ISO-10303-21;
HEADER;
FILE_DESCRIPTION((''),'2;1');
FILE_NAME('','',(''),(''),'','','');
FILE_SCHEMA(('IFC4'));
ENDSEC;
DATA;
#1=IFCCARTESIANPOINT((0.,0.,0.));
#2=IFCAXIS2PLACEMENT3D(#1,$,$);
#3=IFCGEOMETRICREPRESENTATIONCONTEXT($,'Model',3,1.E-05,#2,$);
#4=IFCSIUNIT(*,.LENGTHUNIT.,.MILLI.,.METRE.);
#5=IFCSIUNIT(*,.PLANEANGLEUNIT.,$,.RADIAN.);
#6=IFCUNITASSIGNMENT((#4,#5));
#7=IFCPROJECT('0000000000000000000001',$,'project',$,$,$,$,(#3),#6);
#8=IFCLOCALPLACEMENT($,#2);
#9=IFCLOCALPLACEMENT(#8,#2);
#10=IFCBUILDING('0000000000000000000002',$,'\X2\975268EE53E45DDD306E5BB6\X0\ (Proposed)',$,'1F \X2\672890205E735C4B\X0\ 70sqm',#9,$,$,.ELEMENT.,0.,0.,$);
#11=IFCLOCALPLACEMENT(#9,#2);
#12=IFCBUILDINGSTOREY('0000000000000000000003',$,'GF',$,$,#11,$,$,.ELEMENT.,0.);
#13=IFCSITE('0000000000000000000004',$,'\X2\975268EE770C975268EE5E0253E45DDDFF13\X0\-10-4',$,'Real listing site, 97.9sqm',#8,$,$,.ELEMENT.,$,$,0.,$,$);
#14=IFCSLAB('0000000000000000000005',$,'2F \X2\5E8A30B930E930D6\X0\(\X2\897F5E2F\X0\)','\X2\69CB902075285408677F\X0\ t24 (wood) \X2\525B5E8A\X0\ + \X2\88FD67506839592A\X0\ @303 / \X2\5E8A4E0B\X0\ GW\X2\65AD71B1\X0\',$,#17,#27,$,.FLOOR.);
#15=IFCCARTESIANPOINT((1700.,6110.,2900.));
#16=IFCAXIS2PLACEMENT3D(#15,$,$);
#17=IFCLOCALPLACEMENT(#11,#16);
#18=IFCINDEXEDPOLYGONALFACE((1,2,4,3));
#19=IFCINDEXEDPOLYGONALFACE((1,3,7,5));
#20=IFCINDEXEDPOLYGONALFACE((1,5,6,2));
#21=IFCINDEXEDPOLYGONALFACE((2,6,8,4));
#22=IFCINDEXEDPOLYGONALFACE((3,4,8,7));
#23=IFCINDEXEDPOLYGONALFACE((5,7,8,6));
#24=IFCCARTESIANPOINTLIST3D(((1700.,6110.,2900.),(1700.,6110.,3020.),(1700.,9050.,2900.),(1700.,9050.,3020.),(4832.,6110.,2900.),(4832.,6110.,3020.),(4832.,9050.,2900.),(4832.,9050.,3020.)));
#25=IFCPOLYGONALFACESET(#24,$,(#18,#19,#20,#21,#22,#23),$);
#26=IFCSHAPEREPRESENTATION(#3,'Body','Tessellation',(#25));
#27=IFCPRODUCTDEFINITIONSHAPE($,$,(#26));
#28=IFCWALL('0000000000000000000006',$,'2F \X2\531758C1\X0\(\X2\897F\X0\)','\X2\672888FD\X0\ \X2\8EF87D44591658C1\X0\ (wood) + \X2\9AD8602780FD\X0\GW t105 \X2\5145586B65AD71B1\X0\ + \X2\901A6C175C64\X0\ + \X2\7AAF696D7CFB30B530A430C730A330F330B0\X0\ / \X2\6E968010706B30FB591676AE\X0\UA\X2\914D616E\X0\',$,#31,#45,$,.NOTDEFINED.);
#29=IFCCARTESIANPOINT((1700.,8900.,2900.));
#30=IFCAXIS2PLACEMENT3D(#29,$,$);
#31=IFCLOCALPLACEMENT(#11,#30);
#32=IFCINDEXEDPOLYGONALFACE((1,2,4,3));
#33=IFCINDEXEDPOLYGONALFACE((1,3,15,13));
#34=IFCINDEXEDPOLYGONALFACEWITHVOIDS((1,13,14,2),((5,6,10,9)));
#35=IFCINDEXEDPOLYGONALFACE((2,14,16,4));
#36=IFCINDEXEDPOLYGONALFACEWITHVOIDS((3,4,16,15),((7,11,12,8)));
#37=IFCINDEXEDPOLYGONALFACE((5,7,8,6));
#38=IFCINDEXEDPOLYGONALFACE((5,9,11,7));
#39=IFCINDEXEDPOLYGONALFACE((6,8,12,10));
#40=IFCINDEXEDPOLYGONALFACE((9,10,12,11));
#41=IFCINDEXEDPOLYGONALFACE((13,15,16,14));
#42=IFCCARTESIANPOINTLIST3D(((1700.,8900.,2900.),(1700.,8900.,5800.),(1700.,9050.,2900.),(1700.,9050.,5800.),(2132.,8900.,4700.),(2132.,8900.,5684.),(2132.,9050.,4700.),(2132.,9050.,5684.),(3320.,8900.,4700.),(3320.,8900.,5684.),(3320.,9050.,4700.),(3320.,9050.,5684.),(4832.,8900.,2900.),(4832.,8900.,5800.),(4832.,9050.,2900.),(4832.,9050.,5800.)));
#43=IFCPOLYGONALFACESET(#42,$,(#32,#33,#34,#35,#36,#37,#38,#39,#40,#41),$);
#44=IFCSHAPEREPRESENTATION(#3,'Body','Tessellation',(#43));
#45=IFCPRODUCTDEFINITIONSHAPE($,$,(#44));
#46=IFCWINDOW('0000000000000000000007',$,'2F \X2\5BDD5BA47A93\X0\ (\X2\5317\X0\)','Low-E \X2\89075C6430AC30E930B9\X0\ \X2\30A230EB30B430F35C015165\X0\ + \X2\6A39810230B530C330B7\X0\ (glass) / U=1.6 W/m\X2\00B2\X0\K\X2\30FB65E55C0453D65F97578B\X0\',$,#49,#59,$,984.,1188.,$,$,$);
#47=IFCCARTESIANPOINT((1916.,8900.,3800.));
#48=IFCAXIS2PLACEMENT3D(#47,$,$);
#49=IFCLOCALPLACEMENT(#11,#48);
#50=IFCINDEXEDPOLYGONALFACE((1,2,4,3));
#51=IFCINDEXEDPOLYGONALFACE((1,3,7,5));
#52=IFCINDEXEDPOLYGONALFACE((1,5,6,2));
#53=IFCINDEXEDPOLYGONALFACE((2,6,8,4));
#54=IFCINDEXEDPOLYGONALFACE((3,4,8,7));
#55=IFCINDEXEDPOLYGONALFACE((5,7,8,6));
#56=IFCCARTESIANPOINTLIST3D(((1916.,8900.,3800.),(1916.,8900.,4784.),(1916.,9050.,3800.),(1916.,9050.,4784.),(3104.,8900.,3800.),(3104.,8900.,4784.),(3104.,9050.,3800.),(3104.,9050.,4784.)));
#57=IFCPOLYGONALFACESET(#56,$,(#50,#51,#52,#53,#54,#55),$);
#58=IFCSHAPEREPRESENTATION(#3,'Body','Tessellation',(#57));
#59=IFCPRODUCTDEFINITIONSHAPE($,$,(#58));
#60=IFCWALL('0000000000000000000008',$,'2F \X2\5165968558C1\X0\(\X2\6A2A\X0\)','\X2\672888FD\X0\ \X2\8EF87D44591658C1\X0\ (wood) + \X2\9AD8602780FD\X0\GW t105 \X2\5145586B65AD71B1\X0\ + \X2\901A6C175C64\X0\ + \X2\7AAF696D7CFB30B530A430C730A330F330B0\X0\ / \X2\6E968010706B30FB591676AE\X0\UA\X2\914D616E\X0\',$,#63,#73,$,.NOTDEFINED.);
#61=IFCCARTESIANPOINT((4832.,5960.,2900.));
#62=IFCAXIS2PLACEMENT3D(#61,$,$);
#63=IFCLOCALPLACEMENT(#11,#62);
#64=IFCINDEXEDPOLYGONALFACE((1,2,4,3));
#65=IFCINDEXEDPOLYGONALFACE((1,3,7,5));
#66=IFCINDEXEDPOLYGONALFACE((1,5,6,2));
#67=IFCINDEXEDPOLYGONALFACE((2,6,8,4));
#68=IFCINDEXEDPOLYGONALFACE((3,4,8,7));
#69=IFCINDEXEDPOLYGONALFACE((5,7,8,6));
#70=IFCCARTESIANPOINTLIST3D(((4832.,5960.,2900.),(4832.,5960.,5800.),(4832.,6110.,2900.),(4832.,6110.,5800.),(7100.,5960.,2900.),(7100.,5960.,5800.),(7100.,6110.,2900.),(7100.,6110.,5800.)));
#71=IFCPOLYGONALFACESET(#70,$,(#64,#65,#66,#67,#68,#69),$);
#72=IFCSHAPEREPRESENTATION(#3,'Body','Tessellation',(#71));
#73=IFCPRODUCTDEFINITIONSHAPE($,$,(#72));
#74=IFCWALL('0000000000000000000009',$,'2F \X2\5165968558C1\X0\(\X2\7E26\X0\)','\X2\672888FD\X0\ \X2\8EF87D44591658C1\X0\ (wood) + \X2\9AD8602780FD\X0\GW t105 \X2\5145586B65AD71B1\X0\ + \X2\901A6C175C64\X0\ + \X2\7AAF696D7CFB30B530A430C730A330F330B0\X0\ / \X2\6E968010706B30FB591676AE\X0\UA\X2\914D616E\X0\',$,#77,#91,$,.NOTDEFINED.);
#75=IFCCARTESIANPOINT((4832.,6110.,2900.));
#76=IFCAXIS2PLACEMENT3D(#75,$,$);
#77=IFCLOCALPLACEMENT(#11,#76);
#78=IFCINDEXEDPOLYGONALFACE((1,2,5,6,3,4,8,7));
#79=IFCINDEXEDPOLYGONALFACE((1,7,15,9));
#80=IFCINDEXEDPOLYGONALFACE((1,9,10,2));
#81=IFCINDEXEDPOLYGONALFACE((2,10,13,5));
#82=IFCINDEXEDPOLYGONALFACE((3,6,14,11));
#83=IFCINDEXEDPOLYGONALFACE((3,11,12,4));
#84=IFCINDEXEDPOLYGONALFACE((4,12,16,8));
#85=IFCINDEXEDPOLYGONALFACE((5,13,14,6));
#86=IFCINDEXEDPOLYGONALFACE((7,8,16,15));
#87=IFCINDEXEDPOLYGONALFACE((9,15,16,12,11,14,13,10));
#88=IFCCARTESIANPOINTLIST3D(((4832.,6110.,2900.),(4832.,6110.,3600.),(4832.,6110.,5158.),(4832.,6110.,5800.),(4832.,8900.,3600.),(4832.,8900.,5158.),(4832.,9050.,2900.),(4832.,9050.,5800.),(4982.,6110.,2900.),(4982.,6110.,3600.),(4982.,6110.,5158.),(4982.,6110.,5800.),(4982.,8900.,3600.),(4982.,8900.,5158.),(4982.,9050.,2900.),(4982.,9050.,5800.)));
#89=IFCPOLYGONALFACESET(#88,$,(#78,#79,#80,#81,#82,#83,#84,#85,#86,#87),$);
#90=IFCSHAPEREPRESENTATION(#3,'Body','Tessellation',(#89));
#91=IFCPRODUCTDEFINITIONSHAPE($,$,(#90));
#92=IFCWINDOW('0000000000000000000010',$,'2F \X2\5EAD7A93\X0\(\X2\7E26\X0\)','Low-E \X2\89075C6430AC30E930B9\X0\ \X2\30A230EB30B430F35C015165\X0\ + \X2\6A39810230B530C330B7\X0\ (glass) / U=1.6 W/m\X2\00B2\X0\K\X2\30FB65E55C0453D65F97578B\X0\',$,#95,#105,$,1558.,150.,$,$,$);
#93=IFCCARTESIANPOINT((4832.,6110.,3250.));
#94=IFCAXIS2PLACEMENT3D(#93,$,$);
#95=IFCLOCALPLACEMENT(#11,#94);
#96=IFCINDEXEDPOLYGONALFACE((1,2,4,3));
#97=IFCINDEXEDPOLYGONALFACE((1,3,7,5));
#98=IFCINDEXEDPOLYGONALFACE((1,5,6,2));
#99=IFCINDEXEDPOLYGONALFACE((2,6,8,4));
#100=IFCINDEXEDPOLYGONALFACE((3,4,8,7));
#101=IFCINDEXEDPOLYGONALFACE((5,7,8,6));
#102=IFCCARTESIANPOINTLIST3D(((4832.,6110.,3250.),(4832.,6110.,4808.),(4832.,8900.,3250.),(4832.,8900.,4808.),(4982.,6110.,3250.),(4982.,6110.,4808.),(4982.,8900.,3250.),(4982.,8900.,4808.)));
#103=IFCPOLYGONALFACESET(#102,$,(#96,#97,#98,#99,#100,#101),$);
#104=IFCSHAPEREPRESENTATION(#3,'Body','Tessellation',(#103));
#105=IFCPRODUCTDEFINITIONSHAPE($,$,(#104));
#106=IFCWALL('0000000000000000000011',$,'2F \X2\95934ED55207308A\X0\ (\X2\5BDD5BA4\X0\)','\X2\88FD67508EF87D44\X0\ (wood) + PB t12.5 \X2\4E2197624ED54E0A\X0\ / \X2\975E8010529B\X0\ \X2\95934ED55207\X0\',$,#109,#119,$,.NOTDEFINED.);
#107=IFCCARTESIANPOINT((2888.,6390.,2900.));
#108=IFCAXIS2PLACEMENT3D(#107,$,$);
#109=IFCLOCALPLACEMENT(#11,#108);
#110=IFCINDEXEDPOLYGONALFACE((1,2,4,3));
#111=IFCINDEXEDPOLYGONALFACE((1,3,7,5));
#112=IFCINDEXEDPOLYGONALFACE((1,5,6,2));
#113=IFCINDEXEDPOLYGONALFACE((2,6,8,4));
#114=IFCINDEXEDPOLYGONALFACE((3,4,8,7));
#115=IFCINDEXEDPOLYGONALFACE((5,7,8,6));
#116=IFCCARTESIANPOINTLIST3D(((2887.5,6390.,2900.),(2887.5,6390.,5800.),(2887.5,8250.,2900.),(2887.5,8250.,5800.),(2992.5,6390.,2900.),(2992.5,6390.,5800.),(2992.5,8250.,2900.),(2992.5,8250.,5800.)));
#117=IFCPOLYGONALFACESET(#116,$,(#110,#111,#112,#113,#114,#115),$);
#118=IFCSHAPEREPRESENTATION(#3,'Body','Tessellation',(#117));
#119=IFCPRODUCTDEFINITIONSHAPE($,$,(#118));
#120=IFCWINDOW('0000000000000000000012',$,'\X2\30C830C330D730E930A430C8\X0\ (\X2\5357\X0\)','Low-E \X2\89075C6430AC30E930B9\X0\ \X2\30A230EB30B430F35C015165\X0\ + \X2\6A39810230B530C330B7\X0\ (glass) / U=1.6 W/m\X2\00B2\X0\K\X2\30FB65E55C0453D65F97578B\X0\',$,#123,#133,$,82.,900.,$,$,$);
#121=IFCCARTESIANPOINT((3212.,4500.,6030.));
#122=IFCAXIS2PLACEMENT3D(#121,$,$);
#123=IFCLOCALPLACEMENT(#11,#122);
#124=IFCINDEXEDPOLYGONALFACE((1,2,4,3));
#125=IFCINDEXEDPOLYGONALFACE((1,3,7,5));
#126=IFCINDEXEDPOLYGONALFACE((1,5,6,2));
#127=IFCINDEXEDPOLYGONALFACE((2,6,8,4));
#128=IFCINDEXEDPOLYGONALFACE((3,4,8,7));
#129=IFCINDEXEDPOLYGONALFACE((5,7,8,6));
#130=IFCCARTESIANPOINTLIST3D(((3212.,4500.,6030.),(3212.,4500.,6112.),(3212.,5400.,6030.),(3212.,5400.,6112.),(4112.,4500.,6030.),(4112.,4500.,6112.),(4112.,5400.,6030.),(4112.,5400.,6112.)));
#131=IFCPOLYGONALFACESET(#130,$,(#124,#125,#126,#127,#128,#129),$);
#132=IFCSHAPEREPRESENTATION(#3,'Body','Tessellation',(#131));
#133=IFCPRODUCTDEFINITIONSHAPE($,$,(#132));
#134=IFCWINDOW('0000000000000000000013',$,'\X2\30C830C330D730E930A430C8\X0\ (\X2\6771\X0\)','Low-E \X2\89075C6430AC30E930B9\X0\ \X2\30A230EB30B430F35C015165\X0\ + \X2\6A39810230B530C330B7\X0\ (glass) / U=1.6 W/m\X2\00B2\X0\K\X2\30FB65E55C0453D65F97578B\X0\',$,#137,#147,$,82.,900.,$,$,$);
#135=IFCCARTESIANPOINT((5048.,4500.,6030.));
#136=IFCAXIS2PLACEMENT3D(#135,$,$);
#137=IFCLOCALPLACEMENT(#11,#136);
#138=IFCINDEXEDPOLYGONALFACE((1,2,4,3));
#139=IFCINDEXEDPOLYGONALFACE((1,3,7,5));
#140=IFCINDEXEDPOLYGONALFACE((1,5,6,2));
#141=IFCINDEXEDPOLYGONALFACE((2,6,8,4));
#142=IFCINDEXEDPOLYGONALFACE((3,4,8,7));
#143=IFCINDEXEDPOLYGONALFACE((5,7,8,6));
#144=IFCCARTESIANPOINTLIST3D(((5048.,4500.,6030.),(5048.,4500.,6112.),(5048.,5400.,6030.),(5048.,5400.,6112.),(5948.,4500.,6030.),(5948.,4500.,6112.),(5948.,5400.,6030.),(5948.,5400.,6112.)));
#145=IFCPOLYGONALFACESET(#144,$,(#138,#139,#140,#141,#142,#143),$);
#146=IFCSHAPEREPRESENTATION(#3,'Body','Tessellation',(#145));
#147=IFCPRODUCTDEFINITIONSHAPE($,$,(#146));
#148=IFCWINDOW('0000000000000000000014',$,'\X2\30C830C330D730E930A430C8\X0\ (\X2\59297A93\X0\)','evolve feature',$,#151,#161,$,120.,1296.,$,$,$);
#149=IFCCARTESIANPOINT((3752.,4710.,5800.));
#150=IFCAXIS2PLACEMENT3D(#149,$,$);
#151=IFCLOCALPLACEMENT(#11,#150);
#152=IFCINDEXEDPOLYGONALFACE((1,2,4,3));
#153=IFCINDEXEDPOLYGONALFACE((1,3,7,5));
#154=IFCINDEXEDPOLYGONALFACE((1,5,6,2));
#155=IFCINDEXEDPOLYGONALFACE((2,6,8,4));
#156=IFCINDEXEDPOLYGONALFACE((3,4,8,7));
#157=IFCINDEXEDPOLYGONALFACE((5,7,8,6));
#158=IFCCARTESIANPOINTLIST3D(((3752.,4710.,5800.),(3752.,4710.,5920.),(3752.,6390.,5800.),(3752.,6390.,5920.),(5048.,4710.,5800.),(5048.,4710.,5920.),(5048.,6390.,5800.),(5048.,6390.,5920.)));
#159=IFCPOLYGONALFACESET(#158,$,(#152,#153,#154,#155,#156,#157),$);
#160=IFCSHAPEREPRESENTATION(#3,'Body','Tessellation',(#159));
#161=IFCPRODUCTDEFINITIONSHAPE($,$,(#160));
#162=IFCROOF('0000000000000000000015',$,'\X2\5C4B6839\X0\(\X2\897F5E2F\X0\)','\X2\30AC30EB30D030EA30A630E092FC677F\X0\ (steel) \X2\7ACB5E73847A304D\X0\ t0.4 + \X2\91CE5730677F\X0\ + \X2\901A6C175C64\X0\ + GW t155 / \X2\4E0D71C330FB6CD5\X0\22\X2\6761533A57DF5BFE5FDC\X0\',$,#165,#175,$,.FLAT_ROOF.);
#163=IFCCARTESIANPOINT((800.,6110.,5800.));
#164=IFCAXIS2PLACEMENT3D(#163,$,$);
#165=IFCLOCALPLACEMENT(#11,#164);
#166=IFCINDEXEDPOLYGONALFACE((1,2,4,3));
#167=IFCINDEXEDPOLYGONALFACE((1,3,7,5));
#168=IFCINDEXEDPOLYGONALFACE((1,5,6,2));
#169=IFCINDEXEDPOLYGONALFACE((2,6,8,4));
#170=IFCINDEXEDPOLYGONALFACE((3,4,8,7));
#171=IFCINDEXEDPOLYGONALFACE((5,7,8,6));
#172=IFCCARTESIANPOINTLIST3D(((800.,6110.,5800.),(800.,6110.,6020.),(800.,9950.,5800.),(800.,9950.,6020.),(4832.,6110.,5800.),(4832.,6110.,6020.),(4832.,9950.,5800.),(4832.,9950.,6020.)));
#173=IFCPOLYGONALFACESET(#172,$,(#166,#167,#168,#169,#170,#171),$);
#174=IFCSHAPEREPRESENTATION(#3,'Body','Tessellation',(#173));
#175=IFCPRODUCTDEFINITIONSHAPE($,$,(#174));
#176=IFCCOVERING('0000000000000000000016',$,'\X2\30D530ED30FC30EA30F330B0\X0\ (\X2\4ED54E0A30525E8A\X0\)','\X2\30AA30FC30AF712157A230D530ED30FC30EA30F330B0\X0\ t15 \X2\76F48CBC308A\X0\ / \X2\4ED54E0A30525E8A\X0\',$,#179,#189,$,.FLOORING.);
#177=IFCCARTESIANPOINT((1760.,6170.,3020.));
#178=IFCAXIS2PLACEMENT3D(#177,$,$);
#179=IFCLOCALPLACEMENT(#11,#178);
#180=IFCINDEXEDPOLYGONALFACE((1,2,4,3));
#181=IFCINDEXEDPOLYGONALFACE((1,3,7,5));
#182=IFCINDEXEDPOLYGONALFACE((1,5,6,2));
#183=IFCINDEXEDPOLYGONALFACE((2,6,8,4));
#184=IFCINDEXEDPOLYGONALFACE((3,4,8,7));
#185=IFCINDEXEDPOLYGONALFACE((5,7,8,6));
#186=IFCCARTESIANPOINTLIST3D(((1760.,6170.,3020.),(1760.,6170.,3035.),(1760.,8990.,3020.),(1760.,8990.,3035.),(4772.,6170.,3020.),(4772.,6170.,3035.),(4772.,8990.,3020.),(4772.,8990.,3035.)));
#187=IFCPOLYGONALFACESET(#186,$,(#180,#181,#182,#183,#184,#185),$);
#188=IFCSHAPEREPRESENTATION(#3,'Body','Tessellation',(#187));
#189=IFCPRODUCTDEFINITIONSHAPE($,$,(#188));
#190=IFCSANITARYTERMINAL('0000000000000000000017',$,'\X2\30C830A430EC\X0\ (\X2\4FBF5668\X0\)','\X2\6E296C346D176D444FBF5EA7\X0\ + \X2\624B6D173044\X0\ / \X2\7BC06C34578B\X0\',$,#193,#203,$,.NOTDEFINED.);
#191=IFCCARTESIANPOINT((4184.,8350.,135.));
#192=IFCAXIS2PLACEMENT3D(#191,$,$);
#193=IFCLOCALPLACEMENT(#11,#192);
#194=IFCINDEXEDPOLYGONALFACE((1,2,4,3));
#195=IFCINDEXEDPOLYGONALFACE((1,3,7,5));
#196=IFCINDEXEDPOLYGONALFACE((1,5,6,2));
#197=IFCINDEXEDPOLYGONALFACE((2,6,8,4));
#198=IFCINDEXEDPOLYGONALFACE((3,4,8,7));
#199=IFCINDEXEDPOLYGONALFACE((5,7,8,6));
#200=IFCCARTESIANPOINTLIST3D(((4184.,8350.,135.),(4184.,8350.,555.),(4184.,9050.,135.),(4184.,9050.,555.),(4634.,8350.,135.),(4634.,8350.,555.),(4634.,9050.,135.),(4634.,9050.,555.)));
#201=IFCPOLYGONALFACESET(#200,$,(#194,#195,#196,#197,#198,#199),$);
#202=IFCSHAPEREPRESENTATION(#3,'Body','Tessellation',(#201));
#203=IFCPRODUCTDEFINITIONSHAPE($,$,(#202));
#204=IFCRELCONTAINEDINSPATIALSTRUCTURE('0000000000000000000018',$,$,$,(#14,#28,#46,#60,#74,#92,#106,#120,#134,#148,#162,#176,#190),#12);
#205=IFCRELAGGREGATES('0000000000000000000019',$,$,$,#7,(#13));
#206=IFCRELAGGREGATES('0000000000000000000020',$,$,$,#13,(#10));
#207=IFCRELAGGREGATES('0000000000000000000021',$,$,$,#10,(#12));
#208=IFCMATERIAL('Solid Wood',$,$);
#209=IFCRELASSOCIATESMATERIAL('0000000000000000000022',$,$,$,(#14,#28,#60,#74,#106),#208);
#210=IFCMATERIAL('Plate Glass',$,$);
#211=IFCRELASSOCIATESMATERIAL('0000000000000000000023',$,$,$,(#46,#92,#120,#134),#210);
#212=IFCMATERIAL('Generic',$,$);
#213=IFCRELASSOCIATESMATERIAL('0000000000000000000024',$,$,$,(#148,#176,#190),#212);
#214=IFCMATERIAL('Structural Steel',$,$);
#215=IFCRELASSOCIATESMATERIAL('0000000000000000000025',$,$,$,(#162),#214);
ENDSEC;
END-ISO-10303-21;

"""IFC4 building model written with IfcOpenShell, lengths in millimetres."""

from ifc_helpers import new_model, si_unit, frame, frame_2d, origin, place, context, project, spatial, rectangle, extrude, material, element, fill, save


model = new_model("IFC4")

# Units and contexts
model_context = context("Model", 3, precision=1e-05, world=origin())
ifc_project = project(units=[si_unit("LENGTHUNIT", "METRE", prefix="MILLI"), si_unit("PLANEANGLEUNIT", "RADIAN")], contexts=[model_context])

# Site, building, storey
site_placement = place(None, origin())
site = spatial("IfcSite", under=ifc_project, at=site_placement, Name="青森県青森市古川３-10-4", ObjectType="Real listing site, 97.9sqm", CompositionType="ELEMENT", RefElevation=0.0)
building_placement = place(site_placement, origin())
building = spatial("IfcBuilding", under=site, at=building_placement, Name="青森古川の家 (Proposed)", ObjectType="1F 木造平屋 70sqm", CompositionType="ELEMENT", ElevationOfRefHeight=0.0, ElevationOfTerrain=0.0)
storey_placement = place(building_placement, origin())
storey = spatial("IfcBuildingStorey", under=building, at=storey_placement, Name="GF", CompositionType="ELEMENT", Elevation=0.0)

# Slab
ifc_material_1 = material(Name="Solid Wood")
slab_placement = place(storey_placement, frame((1700.0, 6110.0, 2900.0)))
element("IfcSlab", 1, at=slab_placement, inside=storey, material=ifc_material_1, Name="2F 床スラブ(西帯)", Description="構造用合板 t24 (wood) 剛床 + 製材根太 @303 / 床下 GW断熱", PredefinedType="FLOOR", context=model_context, shape_type="SweptSolid", body=[
    extrude(rectangle(XDim=3132.0, YDim=2940.0, at=frame_2d((1566.0, 1470.0))), frame((1700.0, 6110.0, 2900.0)), (0.0, 0.0, 1.0), 120.0),
])

# Wall, opening, window
wall_1_placement = place(storey_placement, frame((1700.0, 8900.0, 2900.0)))
wall_1 = element("IfcWall", 2, at=wall_1_placement, inside=storey, material=ifc_material_1, Name="2F 北壁(西)", Description="木製 軸組外壁 (wood) + 高性能GW t105 充填断熱 + 通気層 + 窯業系サイディング / 準耐火・外皮UA配慮", PredefinedType="NOTDEFINED", context=model_context, shape_type="SweptSolid", body=[
    extrude(rectangle(XDim=3132.0, YDim=150.0, at=frame_2d((1566.0, 75.0))), frame((1700.0, 8900.0, 2900.0)), (0.0, 0.0, 1.0), 2900.0),
])
opening_1_placement = place(storey_placement, frame((1916.0, 8900.0, 3800.0)))
opening_1 = element("IfcOpeningElement", 3, at=opening_1_placement, cuts=wall_1, PredefinedType="NOTDEFINED", context=model_context, shape_type="SweptSolid", body=[
    extrude(rectangle(XDim=1188.0, YDim=150.0, at=frame_2d((594.0, 75.0))), frame((1916.0, 8900.0, 3800.0)), (0.0, 0.0, 1.0), 984.0),
])
ifc_material_2 = material(Name="Plate Glass")
window_1_placement = place(storey_placement, frame((1916.0, 8900.0, 3800.0)))
window_1 = element("IfcWindow", 4, at=window_1_placement, inside=storey, material=ifc_material_2, Name="2F 寝室窓 (北)", Description="Low-E 複層ガラス アルゴン封入 + 樹脂サッシ (glass) / U=1.6 W/m²K・日射取得型", OverallHeight=984.0, OverallWidth=1188.0, context=model_context, shape_type="SweptSolid", body=[
    extrude(rectangle(XDim=1188.0, YDim=150.0, at=frame_2d((594.0, 75.0))), frame((1916.0, 8900.0, 3800.0)), (0.0, 0.0, 1.0), 984.0),
])
fill(opening_1, window_1)

# Wall
wall_2_placement = place(storey_placement, frame((4832.0, 5960.0, 2900.0)))
element("IfcWall", 5, at=wall_2_placement, inside=storey, material=ifc_material_1, Name="2F 入隅壁(横)", Description="木製 軸組外壁 (wood) + 高性能GW t105 充填断熱 + 通気層 + 窯業系サイディング / 準耐火・外皮UA配慮", PredefinedType="NOTDEFINED", context=model_context, shape_type="SweptSolid", body=[
    extrude(rectangle(XDim=2268.0, YDim=150.0, at=frame_2d((1134.0, 75.0))), frame((4832.0, 5960.0, 2900.0)), (0.0, 0.0, 1.0), 2900.0),
])

# Wall, opening, window
wall_3_placement = place(storey_placement, frame((4832.0, 6110.0, 2900.0)))
wall_3 = element("IfcWall", 6, at=wall_3_placement, inside=storey, material=ifc_material_1, Name="2F 入隅壁(縦)", Description="木製 軸組外壁 (wood) + 高性能GW t105 充填断熱 + 通気層 + 窯業系サイディング / 準耐火・外皮UA配慮", PredefinedType="NOTDEFINED", context=model_context, shape_type="SweptSolid", body=[
    extrude(rectangle(XDim=150.0, YDim=2940.0, at=frame_2d((75.0, 1470.0))), frame((4832.0, 6110.0, 2900.0)), (0.0, 0.0, 1.0), 2900.0),
])
opening_2_placement = place(storey_placement, frame((4832.0, 6110.0, 3250.0)))
opening_2 = element("IfcOpeningElement", 7, at=opening_2_placement, cuts=wall_3, PredefinedType="NOTDEFINED", context=model_context, shape_type="SweptSolid", body=[
    extrude(rectangle(XDim=150.0, YDim=2790.0, at=frame_2d((75.0, 1395.0))), frame((4832.0, 6110.0, 3250.0)), (0.0, 0.0, 1.0), 1558.0),
])
window_2_placement = place(storey_placement, frame((4832.0, 6110.0, 3250.0)))
window_2 = element("IfcWindow", 8, at=window_2_placement, inside=storey, material=ifc_material_2, Name="2F 庭窓(縦)", Description="Low-E 複層ガラス アルゴン封入 + 樹脂サッシ (glass) / U=1.6 W/m²K・日射取得型", OverallHeight=1558.0, OverallWidth=150.0, context=model_context, shape_type="SweptSolid", body=[
    extrude(rectangle(XDim=150.0, YDim=2790.0, at=frame_2d((75.0, 1395.0))), frame((4832.0, 6110.0, 3250.0)), (0.0, 0.0, 1.0), 1558.0),
])
fill(opening_2, window_2)

# Wall
wall_4_placement = place(storey_placement, frame((2888.0, 6390.0, 2900.0)))
element("IfcWall", 9, at=wall_4_placement, inside=storey, material=ifc_material_1, Name="2F 間仕切り (寝室)", Description="製材軸組 (wood) + PB t12.5 両面仕上 / 非耐力 間仕切", PredefinedType="NOTDEFINED", context=model_context, shape_type="SweptSolid", body=[
    extrude(rectangle(XDim=105.0, YDim=1860.0, at=frame_2d((52.0, 930.0))), frame((2888.0, 6390.0, 2900.0)), (0.0, 0.0, 1.0), 2900.0),
])

# Windows
window_3_placement = place(storey_placement, frame((3212.0, 4500.0, 6030.0)))
element("IfcWindow", 10, at=window_3_placement, inside=storey, material=ifc_material_2, Name="トップライト (南)", Description="Low-E 複層ガラス アルゴン封入 + 樹脂サッシ (glass) / U=1.6 W/m²K・日射取得型", OverallHeight=82.0, OverallWidth=900.0, context=model_context, shape_type="SweptSolid", body=[
    extrude(rectangle(XDim=900.0, YDim=900.0, at=frame_2d((450.0, 450.0))), frame((3212.0, 4500.0, 6030.0)), (0.0, 0.0, 1.0), 82.0),
])
window_4_placement = place(storey_placement, frame((5048.0, 4500.0, 6030.0)))
element("IfcWindow", 11, at=window_4_placement, inside=storey, material=ifc_material_2, Name="トップライト (東)", Description="Low-E 複層ガラス アルゴン封入 + 樹脂サッシ (glass) / U=1.6 W/m²K・日射取得型", OverallHeight=82.0, OverallWidth=900.0, context=model_context, shape_type="SweptSolid", body=[
    extrude(rectangle(XDim=900.0, YDim=900.0, at=frame_2d((450.0, 450.0))), frame((5048.0, 4500.0, 6030.0)), (0.0, 0.0, 1.0), 82.0),
])
ifc_material_3 = material(Name="Generic")
window_5_placement = place(storey_placement, frame((3752.0, 4710.0, 5800.0)))
element("IfcWindow", 12, at=window_5_placement, inside=storey, material=ifc_material_3, Name="トップライト (天窓)", Description="evolve feature", OverallHeight=120.0, OverallWidth=1296.0, context=model_context, shape_type="SweptSolid", body=[
    extrude(rectangle(XDim=1296.0, YDim=1680.0, at=frame_2d((648.0, 840.0))), frame((3752.0, 4710.0, 5800.0)), (0.0, 0.0, 1.0), 120.0),
])

# Roof
ifc_material_4 = material(Name="Structural Steel")
for number, where, name in (
    (13, (800.0, 6110.0, 5800.0), "屋根(西帯)"),
):
    element("IfcRoof", number, at=place(storey_placement, frame(where)), inside=storey, material=ifc_material_4, Name=name, Description="ガルバリウム鋼板 (steel) 立平葺き t0.4 + 野地板 + 通気層 + GW t155 / 不燃・法22条区域対応", PredefinedType="FLAT_ROOF", context=model_context, shape_type="SweptSolid", body=[
        extrude(rectangle(XDim=4032.0, YDim=3840.0, at=frame_2d((2016.0, 1920.0))), frame((800.0, 6110.0, 5800.0)), (0.0, 0.0, 1.0), 220.0),
    ])

# Covering
covering_placement = place(storey_placement, frame((1760.0, 6170.0, 3020.0)))
element("IfcCovering", 14, at=covering_placement, inside=storey, material=ifc_material_3, Name="フローリング (仕上げ床)", Description="オーク無垢フローリング t15 直貼り / 仕上げ床", PredefinedType="FLOORING", context=model_context, shape_type="SweptSolid", body=[
    extrude(rectangle(XDim=3012.0, YDim=2820.0, at=frame_2d((1506.0, 1410.0))), frame((1760.0, 6170.0, 3020.0)), (0.0, 0.0, 1.0), 15.0),
])

# Sanitary terminal
sanitary_terminal_placement = place(storey_placement, frame((4184.0, 8350.0, 135.0)))
element("IfcSanitaryTerminal", 15, at=sanitary_terminal_placement, inside=storey, material=ifc_material_3, Name="トイレ (便器)", Description="温水洗浄便座 + 手洗い / 節水型", PredefinedType="NOTDEFINED", context=model_context, shape_type="SweptSolid", body=[
    extrude(rectangle(XDim=450.0, YDim=700.0, at=frame_2d((225.0, 350.0))), frame((4184.0, 8350.0, 135.0)), (0.0, 0.0, 1.0), 420.0),
])

save(model, "model.ifc")
